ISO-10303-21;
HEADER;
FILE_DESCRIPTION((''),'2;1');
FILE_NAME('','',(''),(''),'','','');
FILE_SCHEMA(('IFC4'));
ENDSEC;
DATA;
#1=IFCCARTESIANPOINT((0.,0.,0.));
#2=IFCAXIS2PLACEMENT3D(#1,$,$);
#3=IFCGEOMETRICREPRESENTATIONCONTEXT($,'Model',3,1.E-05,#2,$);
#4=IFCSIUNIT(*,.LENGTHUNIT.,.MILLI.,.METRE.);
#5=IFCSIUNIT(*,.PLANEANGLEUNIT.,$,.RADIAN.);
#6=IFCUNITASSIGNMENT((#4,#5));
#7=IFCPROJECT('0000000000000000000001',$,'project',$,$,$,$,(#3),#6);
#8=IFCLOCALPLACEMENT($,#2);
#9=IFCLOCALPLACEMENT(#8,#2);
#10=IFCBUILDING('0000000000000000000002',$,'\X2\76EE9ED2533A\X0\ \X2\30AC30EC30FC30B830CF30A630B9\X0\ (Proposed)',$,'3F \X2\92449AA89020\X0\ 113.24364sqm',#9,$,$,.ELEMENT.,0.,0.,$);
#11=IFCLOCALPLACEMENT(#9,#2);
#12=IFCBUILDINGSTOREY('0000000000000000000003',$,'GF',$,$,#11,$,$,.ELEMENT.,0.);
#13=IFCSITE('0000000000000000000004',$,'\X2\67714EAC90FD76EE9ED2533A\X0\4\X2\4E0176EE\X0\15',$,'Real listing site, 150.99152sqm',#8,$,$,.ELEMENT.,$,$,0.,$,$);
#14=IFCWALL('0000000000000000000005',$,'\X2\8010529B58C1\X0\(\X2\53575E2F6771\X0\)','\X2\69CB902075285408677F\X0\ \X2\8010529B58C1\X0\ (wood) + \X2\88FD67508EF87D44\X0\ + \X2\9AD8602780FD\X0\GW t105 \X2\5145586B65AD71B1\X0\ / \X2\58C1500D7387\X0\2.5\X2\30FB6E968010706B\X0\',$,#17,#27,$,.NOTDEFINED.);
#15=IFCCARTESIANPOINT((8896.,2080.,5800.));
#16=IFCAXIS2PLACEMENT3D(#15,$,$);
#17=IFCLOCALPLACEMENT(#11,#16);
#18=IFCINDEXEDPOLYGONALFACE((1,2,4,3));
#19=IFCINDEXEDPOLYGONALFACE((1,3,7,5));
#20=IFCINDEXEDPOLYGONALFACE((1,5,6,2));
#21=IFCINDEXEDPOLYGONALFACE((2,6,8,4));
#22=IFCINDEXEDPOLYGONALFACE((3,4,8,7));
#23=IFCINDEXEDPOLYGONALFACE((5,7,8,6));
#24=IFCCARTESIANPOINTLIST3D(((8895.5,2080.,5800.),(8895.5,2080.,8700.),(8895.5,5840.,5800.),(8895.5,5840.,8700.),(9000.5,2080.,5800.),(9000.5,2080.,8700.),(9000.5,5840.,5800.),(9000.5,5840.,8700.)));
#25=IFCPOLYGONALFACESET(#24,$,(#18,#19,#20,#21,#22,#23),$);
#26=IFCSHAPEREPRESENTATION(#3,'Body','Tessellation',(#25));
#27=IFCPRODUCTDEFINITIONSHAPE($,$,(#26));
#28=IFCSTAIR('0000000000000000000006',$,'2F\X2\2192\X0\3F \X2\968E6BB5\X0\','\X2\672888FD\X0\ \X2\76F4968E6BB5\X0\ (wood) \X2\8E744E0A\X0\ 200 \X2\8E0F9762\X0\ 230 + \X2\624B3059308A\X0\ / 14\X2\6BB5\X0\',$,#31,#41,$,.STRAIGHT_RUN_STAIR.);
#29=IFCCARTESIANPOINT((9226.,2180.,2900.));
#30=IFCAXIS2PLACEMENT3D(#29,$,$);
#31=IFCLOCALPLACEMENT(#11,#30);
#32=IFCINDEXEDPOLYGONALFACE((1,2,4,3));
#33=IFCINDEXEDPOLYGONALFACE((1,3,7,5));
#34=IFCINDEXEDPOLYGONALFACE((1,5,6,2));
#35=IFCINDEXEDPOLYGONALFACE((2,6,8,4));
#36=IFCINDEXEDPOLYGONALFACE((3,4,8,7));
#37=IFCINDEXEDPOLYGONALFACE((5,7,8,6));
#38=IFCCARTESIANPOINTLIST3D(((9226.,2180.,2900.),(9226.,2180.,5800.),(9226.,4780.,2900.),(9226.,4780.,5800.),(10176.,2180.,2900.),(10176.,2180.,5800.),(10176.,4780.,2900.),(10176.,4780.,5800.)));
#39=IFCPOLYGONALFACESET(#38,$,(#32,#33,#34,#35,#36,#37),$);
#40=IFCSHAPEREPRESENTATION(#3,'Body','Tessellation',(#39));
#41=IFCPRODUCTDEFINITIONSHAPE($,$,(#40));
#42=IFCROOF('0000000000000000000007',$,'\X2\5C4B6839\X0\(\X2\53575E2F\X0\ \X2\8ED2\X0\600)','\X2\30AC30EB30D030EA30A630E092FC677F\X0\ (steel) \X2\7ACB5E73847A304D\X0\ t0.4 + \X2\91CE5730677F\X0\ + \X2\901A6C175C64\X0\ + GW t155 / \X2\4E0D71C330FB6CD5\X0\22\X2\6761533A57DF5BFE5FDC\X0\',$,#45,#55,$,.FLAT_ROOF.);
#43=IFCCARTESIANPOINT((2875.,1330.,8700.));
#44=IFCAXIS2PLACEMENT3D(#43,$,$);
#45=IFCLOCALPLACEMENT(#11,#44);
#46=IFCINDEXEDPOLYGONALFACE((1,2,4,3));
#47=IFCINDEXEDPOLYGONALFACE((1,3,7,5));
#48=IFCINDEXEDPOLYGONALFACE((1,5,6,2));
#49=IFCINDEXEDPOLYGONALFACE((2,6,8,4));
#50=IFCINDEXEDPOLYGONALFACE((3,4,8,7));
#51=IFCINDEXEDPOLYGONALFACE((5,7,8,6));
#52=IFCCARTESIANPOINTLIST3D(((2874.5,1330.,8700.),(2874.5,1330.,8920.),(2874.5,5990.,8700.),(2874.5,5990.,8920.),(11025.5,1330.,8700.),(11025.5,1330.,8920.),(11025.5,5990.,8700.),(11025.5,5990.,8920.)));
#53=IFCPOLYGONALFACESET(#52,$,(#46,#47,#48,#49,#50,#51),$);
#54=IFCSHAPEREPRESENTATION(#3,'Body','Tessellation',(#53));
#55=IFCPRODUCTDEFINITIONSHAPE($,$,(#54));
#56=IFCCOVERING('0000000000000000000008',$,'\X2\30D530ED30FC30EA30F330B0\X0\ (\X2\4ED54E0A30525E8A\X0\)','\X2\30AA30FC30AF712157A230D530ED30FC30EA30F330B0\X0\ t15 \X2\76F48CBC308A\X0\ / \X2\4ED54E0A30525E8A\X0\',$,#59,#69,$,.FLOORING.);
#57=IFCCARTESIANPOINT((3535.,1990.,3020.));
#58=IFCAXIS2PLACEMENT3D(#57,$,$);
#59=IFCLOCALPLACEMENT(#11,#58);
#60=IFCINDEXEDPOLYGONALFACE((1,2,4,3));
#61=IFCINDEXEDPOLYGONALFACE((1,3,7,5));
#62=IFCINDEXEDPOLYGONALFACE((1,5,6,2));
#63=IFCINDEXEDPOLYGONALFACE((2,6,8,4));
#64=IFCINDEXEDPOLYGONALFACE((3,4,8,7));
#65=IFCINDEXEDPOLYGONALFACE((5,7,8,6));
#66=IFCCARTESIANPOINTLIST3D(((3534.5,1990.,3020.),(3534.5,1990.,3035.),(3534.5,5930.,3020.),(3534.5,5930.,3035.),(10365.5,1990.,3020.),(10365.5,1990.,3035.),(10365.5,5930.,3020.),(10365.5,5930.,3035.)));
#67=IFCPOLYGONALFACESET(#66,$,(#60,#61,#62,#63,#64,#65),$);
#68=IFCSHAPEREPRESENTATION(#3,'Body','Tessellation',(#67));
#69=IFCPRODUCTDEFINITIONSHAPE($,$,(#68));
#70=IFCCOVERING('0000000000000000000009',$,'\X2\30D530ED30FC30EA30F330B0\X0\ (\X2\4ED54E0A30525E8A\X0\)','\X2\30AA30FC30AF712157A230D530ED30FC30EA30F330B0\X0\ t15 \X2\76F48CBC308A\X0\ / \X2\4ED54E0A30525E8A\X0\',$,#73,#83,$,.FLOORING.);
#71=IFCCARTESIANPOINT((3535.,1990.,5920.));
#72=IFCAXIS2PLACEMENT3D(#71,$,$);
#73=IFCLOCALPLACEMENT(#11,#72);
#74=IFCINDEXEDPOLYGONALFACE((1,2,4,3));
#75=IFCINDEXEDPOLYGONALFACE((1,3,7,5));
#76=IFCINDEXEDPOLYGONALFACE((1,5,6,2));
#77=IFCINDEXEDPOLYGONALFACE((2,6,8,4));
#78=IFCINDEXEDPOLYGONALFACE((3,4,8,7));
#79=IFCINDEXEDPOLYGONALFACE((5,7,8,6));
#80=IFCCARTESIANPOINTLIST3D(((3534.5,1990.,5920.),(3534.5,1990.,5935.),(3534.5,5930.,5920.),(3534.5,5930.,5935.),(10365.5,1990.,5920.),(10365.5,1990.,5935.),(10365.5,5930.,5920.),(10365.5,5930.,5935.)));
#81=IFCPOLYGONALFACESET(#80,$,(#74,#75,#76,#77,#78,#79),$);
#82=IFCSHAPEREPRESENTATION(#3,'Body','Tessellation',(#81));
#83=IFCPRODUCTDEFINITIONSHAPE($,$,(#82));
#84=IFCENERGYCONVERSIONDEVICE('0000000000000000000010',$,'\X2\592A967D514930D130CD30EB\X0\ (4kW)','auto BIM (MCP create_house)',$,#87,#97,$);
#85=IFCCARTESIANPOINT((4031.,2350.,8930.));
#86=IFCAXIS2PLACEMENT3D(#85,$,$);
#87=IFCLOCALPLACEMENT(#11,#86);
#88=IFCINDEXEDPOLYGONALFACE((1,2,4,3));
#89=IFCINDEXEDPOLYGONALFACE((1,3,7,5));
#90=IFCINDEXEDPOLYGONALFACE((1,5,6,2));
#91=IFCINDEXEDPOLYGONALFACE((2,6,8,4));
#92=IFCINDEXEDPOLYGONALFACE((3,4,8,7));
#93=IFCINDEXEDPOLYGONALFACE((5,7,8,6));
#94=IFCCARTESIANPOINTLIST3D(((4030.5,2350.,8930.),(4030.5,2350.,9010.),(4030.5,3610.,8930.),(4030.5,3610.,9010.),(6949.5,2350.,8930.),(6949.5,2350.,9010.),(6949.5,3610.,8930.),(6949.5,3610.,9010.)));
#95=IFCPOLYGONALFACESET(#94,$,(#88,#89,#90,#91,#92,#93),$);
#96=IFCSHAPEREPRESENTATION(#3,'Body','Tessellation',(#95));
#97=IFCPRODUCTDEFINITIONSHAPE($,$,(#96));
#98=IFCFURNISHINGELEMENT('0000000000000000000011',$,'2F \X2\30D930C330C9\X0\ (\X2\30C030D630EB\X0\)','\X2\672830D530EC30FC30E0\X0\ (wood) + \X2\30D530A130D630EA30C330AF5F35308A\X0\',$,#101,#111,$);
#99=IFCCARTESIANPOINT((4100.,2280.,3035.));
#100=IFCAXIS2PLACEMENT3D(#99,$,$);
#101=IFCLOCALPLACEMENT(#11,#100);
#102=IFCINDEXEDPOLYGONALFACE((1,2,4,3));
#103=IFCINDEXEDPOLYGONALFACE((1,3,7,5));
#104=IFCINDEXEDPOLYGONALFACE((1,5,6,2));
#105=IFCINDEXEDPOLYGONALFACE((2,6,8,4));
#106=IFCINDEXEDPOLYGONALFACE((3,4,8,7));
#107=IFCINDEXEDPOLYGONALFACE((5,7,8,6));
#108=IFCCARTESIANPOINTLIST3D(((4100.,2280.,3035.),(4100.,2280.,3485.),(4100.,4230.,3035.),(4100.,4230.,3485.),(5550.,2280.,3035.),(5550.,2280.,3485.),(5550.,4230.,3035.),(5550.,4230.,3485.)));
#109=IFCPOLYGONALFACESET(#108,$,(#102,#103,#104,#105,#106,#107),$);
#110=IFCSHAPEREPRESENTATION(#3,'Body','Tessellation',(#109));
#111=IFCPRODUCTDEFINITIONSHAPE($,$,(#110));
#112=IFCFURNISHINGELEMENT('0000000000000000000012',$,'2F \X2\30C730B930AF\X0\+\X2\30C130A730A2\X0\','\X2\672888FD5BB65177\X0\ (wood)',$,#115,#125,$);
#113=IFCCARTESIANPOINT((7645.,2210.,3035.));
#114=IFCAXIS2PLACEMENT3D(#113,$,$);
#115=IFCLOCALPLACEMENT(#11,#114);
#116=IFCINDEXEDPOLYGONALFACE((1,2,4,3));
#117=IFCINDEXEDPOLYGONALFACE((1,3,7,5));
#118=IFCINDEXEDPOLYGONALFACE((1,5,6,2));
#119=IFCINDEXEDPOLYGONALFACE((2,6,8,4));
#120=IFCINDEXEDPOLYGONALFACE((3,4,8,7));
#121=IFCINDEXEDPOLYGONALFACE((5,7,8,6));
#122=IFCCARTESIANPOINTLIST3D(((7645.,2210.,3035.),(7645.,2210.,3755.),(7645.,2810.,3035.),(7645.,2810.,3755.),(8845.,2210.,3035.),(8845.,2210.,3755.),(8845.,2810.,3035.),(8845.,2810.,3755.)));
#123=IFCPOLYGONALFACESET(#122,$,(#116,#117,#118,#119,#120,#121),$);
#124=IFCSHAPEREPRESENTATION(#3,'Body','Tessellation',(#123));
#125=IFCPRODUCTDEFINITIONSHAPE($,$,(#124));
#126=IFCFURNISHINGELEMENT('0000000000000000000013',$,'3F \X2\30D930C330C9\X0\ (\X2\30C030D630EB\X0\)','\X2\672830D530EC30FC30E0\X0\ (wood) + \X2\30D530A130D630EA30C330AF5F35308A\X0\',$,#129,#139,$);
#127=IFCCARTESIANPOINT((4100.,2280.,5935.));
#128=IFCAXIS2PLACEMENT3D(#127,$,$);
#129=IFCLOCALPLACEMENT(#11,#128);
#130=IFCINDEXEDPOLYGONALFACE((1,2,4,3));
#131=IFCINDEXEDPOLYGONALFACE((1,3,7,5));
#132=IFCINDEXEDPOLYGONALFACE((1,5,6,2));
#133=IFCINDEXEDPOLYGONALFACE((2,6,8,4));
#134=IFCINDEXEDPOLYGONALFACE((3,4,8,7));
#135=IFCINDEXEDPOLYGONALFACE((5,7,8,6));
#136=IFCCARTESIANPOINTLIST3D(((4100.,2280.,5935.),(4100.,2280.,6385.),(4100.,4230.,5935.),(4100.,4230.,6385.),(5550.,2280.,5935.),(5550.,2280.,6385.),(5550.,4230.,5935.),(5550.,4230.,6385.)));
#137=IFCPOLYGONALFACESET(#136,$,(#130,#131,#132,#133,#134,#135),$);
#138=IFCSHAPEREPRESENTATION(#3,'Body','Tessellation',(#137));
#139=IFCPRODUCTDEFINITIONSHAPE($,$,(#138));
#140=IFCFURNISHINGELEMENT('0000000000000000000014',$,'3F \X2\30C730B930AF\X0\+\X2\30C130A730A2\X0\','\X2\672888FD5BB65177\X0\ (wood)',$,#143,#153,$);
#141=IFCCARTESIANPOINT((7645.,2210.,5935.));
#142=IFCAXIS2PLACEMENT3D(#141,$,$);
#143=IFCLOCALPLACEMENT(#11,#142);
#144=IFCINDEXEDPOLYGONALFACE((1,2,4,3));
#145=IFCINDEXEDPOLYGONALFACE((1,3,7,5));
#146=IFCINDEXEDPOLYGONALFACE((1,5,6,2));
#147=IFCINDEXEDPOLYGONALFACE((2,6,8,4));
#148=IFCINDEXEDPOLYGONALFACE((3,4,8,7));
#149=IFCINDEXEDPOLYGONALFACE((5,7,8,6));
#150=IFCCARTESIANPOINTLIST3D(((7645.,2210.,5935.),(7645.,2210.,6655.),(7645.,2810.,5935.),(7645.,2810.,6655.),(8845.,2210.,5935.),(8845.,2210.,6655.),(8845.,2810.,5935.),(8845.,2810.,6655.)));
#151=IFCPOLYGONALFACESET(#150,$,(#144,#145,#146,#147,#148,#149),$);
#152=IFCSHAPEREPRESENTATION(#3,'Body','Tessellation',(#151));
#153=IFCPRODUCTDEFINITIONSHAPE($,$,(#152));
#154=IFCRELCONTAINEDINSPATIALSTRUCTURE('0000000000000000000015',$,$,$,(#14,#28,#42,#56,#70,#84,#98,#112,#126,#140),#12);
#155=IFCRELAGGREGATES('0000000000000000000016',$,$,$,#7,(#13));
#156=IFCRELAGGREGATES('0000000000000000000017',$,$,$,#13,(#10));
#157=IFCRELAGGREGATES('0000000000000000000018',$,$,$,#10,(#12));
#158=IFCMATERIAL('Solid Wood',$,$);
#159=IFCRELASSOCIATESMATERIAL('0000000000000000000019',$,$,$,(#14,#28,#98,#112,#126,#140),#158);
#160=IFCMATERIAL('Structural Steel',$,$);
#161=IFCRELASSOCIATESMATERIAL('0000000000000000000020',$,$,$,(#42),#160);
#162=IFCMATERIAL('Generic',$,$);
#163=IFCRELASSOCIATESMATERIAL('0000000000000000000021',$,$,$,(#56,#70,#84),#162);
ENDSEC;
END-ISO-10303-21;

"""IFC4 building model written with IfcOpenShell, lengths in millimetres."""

from ifc_helpers import new_model, si_unit, frame, frame_2d, origin, place, context, project, spatial, rectangle, extrude, material, element, save


model = new_model("IFC4")

# Units and contexts
model_context = context("Model", 3, precision=1e-05, world=origin())
ifc_project = project(units=[si_unit("LENGTHUNIT", "METRE", prefix="MILLI"), si_unit("PLANEANGLEUNIT", "RADIAN")], contexts=[model_context])

# Site, building, storey
site_placement = place(None, origin())
site = spatial("IfcSite", under=ifc_project, at=site_placement, Name="東京都目黒区4丁目15", ObjectType="Real listing site, 150.99152sqm", CompositionType="ELEMENT", RefElevation=0.0)
building_placement = place(site_placement, origin())
building = spatial("IfcBuilding", under=site, at=building_placement, Name="目黒区 ガレージハウス (Proposed)", ObjectType="3F 鉄骨造 113.24364sqm", CompositionType="ELEMENT", ElevationOfRefHeight=0.0, ElevationOfTerrain=0.0)
storey_placement = place(building_placement, origin())
storey = spatial("IfcBuildingStorey", under=building, at=storey_placement, Name="GF", CompositionType="ELEMENT", Elevation=0.0)

# Shared definitions
ifc_material_1 = material(Name="Solid Wood")

# Wall
wall_1_placement = place(storey_placement, frame((8896.0, 2080.0, 5800.0)))
element("IfcWall", 1, at=wall_1_placement, inside=storey, material=ifc_material_1, Name="耐力壁(南帯東)", Description="構造用合板 耐力壁 (wood) + 製材軸組 + 高性能GW t105 充填断熱 / 壁倍率2.5・準耐火", PredefinedType="NOTDEFINED", context=model_context, shape_type="SweptSolid", body=[
    extrude(rectangle(XDim=105.0, YDim=3760.0, at=frame_2d((52.0, 1880.0))), frame((8896.0, 2080.0, 5800.0)), (0.0, 0.0, 1.0), 2900.0),
])

# Stair
stair_placement = place(storey_placement, frame((9226.0, 2180.0, 2900.0)))
element("IfcStair", 2, at=stair_placement, inside=storey, material=ifc_material_1, Name="2F→3F 階段", Description="木製 直階段 (wood) 蹴上 200 踏面 230 + 手すり / 14段", PredefinedType="STRAIGHT_RUN_STAIR", context=model_context, shape_type="SweptSolid", body=[
    extrude(rectangle(XDim=950.0, YDim=2600.0, at=frame_2d((475.0, 1300.0))), frame((9226.0, 2180.0, 2900.0)), (0.0, 0.0, 1.0), 2900.0),
])

# Roof
ifc_material_2 = material(Name="Structural Steel")
for number, where, name in (
    (3, (2875.0, 1330.0, 8700.0), "屋根(南帯 軒600)"),
):
    element("IfcRoof", number, at=place(storey_placement, frame(where)), inside=storey, material=ifc_material_2, Name=name, Description="ガルバリウム鋼板 (steel) 立平葺き t0.4 + 野地板 + 通気層 + GW t155 / 不燃・法22条区域対応", PredefinedType="FLAT_ROOF", context=model_context, shape_type="SweptSolid", body=[
        extrude(rectangle(XDim=8151.0, YDim=4660.0, at=frame_2d((4075.0, 2330.0))), frame((2875.0, 1330.0, 8700.0)), (0.0, 0.0, 1.0), 220.0),
    ])

# Coverings
ifc_material_3 = material(Name="Generic")
covering_1_placement = place(storey_placement, frame((3535.0, 1990.0, 3020.0)))
element("IfcCovering", 4, at=covering_1_placement, inside=storey, material=ifc_material_3, Name="フローリング (仕上げ床)", Description="オーク無垢フローリング t15 直貼り / 仕上げ床", PredefinedType="FLOORING", context=model_context, shape_type="SweptSolid", body=[
    extrude(rectangle(XDim=6831.0, YDim=3940.0, at=frame_2d((3415.0, 1970.0))), frame((3535.0, 1990.0, 3020.0)), (0.0, 0.0, 1.0), 15.0),
])
covering_2_placement = place(storey_placement, frame((3535.0, 1990.0, 5920.0)))
element("IfcCovering", 5, at=covering_2_placement, inside=storey, material=ifc_material_3, Name="フローリング (仕上げ床)", Description="オーク無垢フローリング t15 直貼り / 仕上げ床", PredefinedType="FLOORING", context=model_context, shape_type="SweptSolid", body=[
    extrude(rectangle(XDim=6831.0, YDim=3940.0, at=frame_2d((3415.0, 1970.0))), frame((3535.0, 1990.0, 5920.0)), (0.0, 0.0, 1.0), 15.0),
])

# Energy conversion device
energy_conversion_device_placement = place(storey_placement, frame((4031.0, 2350.0, 8930.0)))
element("IfcEnergyConversionDevice", 6, at=energy_conversion_device_placement, inside=storey, material=ifc_material_3, Name="太陽光パネル (4kW)", Description="auto BIM (MCP create_house)", context=model_context, shape_type="SweptSolid", body=[
    extrude(rectangle(XDim=2919.0, YDim=1260.0, at=frame_2d((1459.0, 630.0))), frame((4031.0, 2350.0, 8930.0)), (0.0, 0.0, 1.0), 80.0),
])

# Furnishing elements
furnishing_1_placement = place(storey_placement, frame((4100.0, 2280.0, 3035.0)))
element("IfcFurnishingElement", 7, at=furnishing_1_placement, inside=storey, material=ifc_material_1, Name="2F ベッド (ダブル)", Description="木フレーム (wood) + ファブリック張り", context=model_context, shape_type="SweptSolid", body=[
    extrude(rectangle(XDim=1450.0, YDim=1950.0, at=frame_2d((725.0, 975.0))), frame((4100.0, 2280.0, 3035.0)), (0.0, 0.0, 1.0), 450.0),
])
furnishing_2_placement = place(storey_placement, frame((7645.0, 2210.0, 3035.0)))
element("IfcFurnishingElement", 8, at=furnishing_2_placement, inside=storey, material=ifc_material_1, Name="2F デスク+チェア", Description="木製家具 (wood)", context=model_context, shape_type="SweptSolid", body=[
    extrude(rectangle(XDim=1200.0, YDim=600.0, at=frame_2d((600.0, 300.0))), frame((7645.0, 2210.0, 3035.0)), (0.0, 0.0, 1.0), 720.0),
])
furnishing_3_placement = place(storey_placement, frame((4100.0, 2280.0, 5935.0)))
element("IfcFurnishingElement", 9, at=furnishing_3_placement, inside=storey, material=ifc_material_1, Name="3F ベッド (ダブル)", Description="木フレーム (wood) + ファブリック張り", context=model_context, shape_type="SweptSolid", body=[
    extrude(rectangle(XDim=1450.0, YDim=1950.0, at=frame_2d((725.0, 975.0))), frame((4100.0, 2280.0, 5935.0)), (0.0, 0.0, 1.0), 450.0),
])
furnishing_4_placement = place(storey_placement, frame((7645.0, 2210.0, 5935.0)))
element("IfcFurnishingElement", 10, at=furnishing_4_placement, inside=storey, material=ifc_material_1, Name="3F デスク+チェア", Description="木製家具 (wood)", context=model_context, shape_type="SweptSolid", body=[
    extrude(rectangle(XDim=1200.0, YDim=600.0, at=frame_2d((600.0, 300.0))), frame((7645.0, 2210.0, 5935.0)), (0.0, 0.0, 1.0), 720.0),
])

save(model, "model.ifc")
